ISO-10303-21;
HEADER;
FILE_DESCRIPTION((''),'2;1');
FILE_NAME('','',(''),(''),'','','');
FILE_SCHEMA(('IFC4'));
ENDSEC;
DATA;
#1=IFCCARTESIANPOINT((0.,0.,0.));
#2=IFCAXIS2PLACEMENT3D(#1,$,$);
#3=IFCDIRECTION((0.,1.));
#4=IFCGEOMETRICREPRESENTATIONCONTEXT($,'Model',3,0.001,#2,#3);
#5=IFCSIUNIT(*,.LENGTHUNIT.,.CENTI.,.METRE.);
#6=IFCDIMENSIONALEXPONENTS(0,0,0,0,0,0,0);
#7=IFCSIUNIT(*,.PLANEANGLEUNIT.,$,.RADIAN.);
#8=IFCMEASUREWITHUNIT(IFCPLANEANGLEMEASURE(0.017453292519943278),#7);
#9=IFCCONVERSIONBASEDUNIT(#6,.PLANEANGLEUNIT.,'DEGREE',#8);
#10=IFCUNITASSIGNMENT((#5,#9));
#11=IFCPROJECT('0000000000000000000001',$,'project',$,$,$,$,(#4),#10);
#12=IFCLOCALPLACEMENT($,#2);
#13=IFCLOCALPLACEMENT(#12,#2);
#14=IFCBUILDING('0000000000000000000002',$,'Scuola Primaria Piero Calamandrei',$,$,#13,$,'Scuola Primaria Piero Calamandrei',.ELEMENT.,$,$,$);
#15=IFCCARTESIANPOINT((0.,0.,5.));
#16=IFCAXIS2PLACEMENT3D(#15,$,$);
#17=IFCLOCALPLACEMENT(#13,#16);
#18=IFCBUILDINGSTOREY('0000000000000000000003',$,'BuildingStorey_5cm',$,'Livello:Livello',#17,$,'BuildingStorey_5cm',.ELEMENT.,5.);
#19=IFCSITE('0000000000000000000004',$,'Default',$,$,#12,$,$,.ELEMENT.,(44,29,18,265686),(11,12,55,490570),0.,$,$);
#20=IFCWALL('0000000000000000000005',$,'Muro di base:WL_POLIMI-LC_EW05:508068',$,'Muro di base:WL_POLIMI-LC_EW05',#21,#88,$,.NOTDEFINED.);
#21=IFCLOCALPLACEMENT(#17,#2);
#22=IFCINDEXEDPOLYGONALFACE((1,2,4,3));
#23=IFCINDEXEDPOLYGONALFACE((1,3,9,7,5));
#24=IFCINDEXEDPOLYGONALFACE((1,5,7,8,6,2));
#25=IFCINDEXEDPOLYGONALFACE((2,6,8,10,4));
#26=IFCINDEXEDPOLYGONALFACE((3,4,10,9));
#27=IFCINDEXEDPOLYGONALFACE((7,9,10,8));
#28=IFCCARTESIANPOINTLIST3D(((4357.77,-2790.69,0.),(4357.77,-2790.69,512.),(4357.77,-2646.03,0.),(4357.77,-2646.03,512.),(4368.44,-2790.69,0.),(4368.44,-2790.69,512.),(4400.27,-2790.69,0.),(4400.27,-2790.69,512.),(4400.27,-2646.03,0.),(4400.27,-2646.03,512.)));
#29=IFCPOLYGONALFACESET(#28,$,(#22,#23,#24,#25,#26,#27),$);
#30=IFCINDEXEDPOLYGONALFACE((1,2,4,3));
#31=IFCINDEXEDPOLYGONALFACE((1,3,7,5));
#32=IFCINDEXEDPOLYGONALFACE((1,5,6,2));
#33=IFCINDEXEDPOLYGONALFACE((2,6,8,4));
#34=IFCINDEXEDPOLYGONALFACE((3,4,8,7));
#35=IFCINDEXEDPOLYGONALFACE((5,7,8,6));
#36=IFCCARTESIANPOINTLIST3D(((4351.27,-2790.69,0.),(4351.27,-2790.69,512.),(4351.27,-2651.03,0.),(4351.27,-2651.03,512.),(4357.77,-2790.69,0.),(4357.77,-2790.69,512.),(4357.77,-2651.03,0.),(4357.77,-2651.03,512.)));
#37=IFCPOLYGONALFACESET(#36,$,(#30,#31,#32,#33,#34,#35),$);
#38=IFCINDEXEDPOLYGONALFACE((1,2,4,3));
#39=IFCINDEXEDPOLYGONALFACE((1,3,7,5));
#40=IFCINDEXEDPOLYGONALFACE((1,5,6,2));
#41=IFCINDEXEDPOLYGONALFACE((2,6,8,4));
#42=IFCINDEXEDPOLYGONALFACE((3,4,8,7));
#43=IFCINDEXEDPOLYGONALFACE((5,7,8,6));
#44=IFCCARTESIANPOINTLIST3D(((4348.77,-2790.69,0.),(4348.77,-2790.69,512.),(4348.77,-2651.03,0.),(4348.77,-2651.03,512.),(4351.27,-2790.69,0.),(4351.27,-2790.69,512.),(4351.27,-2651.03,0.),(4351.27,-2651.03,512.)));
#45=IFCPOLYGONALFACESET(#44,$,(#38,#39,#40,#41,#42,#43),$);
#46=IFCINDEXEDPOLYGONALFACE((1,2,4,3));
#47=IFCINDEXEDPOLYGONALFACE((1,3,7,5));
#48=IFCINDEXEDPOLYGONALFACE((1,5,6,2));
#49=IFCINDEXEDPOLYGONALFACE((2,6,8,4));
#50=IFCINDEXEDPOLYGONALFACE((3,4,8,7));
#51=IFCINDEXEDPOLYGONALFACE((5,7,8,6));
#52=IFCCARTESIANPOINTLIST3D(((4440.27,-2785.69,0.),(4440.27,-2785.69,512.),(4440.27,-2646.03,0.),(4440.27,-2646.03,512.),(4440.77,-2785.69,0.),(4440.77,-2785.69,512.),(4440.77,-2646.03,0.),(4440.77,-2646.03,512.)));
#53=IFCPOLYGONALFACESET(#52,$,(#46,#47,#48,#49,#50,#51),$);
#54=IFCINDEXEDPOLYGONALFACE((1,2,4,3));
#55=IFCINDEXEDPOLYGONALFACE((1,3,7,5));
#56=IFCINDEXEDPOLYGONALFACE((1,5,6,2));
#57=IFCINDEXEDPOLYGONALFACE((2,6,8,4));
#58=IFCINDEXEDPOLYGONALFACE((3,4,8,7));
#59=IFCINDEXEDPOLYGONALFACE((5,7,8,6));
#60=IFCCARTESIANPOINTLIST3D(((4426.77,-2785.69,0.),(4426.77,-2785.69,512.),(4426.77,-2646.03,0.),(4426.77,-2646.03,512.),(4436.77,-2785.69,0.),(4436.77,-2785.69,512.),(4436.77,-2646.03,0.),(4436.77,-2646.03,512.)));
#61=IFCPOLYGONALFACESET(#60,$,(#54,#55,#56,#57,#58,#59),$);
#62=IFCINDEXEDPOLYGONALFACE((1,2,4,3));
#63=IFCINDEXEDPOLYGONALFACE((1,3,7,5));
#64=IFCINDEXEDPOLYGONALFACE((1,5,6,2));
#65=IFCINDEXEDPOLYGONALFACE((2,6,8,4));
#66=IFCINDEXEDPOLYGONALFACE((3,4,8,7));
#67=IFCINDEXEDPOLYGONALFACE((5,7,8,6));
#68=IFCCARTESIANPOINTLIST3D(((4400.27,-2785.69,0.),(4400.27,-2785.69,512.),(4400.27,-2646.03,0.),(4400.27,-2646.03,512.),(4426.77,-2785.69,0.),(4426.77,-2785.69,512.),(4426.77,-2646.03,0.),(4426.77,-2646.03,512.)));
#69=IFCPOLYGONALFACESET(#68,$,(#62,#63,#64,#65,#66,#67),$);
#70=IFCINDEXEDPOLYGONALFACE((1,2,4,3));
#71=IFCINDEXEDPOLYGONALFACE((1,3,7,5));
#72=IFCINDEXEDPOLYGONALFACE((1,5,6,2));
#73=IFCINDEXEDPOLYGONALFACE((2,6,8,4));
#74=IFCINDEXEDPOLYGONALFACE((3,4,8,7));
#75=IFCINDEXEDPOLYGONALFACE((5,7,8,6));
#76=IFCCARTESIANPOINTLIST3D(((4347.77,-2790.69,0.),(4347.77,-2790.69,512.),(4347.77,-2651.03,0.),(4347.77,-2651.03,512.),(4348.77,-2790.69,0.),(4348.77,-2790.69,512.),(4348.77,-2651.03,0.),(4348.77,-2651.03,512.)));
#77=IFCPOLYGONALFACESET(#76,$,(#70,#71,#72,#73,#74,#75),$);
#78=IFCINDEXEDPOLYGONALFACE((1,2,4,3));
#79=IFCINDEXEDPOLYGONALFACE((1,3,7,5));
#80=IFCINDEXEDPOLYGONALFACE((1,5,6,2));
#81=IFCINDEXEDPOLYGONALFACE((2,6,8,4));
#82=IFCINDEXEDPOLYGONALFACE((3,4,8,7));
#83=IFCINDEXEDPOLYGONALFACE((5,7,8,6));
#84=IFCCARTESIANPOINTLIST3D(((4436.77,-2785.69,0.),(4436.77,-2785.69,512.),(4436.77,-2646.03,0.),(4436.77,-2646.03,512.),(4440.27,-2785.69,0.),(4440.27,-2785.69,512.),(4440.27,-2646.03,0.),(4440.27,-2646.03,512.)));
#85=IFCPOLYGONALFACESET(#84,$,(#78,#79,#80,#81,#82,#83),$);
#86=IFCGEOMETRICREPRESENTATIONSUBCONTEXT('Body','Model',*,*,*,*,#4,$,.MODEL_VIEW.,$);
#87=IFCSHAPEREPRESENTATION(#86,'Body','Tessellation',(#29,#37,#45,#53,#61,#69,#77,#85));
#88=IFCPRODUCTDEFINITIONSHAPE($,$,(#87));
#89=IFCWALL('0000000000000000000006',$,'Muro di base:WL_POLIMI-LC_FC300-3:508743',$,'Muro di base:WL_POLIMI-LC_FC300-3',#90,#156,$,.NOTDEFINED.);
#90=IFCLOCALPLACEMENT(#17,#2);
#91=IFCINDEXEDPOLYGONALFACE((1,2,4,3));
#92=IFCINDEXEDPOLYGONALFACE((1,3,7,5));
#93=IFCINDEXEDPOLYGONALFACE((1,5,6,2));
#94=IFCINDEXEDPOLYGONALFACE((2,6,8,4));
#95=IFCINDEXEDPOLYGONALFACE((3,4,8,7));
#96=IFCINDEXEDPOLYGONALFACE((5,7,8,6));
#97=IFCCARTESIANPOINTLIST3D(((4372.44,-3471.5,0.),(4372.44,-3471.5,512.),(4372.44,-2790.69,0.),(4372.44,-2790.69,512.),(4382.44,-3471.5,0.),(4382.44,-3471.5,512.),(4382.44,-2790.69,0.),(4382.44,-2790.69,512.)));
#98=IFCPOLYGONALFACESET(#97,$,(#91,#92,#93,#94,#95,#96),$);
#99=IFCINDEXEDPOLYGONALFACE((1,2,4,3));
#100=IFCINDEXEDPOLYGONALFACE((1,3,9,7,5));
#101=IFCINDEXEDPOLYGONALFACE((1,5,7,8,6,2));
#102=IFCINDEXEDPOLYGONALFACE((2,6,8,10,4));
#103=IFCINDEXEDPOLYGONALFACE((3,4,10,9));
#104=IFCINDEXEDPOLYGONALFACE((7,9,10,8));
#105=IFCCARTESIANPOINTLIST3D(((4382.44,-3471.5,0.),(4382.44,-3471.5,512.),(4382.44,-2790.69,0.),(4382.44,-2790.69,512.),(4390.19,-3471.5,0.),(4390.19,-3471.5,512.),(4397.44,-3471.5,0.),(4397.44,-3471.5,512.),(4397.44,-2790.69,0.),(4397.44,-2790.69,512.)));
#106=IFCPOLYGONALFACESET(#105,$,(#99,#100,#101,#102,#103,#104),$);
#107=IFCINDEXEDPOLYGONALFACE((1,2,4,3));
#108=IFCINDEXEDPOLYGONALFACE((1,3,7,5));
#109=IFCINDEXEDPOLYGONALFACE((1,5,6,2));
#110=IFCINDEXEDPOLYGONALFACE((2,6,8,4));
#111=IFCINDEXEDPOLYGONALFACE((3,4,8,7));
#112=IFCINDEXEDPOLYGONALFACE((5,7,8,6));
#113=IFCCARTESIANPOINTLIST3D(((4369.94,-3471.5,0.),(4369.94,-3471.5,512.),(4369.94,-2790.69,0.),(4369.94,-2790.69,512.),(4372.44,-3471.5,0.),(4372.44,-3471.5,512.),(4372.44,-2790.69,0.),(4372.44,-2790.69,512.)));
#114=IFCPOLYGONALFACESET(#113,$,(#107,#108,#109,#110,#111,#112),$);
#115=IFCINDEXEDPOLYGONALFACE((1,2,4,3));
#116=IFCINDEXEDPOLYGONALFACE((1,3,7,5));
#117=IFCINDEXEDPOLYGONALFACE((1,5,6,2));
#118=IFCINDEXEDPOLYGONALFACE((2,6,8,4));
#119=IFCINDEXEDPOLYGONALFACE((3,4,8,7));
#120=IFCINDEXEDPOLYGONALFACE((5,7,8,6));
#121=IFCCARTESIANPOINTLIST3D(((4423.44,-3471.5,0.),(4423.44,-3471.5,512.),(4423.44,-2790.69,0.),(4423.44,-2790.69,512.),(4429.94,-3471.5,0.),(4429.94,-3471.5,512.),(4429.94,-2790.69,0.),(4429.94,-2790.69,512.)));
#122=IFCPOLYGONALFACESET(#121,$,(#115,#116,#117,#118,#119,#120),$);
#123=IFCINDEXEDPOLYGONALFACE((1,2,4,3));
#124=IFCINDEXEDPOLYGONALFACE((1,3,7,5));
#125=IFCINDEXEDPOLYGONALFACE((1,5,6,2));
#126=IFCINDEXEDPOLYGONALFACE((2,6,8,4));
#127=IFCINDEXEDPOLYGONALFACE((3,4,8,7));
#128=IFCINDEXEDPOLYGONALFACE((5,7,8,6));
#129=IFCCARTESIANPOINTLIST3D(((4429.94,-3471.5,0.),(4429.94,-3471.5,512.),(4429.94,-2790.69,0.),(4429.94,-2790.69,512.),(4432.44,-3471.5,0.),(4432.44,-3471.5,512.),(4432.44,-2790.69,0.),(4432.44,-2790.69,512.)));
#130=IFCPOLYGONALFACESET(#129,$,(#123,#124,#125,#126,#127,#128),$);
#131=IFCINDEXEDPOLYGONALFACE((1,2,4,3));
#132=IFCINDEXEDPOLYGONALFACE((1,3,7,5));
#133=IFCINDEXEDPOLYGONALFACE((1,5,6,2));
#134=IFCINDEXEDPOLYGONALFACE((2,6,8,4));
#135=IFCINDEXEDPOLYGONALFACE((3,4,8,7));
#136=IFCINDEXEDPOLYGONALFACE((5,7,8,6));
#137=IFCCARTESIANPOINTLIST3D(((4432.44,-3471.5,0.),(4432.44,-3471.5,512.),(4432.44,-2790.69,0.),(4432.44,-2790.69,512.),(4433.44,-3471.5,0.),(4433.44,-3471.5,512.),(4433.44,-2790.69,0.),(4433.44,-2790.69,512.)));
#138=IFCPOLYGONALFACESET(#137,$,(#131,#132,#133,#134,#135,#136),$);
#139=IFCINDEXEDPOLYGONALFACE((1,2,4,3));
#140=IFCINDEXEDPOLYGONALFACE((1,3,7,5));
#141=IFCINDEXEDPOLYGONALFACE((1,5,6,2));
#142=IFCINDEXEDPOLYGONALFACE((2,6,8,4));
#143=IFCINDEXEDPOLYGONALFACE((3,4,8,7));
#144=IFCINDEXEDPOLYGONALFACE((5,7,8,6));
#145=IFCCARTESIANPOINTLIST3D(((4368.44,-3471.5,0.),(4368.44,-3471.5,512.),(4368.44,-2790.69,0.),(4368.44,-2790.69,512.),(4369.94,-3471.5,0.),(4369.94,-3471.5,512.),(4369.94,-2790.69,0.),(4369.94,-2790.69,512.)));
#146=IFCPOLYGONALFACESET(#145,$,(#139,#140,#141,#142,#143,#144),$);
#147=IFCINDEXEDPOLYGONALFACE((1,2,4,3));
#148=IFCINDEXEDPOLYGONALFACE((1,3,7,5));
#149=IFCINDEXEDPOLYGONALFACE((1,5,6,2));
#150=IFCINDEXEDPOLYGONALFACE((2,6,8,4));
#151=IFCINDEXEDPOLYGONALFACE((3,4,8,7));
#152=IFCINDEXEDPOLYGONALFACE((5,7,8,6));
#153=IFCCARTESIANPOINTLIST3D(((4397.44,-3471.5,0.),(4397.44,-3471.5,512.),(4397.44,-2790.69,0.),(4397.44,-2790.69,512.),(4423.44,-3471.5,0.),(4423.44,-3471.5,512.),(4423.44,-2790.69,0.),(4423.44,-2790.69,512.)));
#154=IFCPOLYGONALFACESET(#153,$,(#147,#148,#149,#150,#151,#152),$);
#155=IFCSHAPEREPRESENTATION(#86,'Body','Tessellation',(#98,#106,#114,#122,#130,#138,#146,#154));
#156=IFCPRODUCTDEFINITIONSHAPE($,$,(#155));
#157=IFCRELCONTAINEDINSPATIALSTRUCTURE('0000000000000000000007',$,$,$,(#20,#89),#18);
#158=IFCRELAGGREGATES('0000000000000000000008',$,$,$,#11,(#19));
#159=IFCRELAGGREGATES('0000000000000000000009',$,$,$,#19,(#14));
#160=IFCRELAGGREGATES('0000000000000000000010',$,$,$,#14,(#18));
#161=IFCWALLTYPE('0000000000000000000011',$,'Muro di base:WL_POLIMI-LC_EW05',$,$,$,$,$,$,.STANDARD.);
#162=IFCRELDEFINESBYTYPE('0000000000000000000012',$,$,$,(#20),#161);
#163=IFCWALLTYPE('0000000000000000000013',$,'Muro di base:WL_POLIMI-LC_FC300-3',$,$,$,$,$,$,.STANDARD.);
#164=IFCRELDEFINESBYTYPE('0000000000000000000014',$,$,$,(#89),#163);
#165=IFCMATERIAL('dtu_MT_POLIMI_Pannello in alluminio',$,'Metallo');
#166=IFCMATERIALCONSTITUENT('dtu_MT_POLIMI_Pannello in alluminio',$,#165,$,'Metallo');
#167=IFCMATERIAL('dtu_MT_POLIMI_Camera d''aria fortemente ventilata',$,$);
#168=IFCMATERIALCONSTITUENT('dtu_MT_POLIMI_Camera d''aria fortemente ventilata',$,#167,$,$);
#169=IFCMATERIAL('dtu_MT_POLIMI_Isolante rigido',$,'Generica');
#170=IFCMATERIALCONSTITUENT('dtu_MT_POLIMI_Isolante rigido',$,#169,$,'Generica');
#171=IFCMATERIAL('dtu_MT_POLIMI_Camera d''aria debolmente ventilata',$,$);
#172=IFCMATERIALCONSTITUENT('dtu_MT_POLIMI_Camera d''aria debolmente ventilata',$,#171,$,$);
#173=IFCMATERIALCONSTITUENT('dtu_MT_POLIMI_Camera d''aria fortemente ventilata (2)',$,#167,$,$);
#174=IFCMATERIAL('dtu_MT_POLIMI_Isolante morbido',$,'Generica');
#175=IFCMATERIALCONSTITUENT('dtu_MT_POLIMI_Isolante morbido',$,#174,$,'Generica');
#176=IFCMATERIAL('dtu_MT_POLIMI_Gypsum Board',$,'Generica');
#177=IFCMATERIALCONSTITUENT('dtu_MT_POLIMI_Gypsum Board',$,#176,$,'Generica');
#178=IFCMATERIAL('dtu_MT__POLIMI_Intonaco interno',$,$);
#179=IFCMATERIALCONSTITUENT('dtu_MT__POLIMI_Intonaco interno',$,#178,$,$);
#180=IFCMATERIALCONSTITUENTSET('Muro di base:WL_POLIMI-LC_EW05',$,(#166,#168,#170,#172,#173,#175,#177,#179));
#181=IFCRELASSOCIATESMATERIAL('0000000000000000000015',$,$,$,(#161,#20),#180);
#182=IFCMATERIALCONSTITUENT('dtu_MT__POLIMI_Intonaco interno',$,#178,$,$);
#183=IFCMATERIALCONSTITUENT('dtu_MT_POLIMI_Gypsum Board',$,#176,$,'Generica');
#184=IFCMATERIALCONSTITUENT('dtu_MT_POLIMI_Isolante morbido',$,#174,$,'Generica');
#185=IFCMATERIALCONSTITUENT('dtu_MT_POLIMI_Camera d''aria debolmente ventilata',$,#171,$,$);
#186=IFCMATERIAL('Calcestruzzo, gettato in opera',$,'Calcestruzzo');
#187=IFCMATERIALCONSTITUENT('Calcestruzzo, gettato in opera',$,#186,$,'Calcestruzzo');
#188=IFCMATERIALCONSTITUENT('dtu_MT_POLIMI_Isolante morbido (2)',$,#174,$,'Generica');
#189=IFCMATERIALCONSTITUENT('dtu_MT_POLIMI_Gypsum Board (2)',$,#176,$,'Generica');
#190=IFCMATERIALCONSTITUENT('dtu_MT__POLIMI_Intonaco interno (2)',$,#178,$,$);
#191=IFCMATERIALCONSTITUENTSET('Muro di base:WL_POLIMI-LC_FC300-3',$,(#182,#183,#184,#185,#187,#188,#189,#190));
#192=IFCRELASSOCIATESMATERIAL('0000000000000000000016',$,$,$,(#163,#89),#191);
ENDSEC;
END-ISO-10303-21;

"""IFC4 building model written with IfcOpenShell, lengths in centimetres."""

from ifc_helpers import new_model, entity, si_unit, converted_unit, direction, frame, origin, place, context, subcontext, project, spatial, indexed_curve, outline, extrude, material, constituent, constituent_set, type_object, element, save


model = new_model("IFC4")

# Units and contexts
model_context = context("Model", 3, precision=0.001, world=origin(), true_north=direction((0.0, 1.0)))
body_context = subcontext(model_context, "Body", "Model", "MODEL_VIEW")
ifc_project = project(units=[si_unit("LENGTHUNIT", "METRE", prefix="CENTI"), converted_unit("PLANEANGLEUNIT", "DEGREE", entity("IfcPlaneAngleMeasure", 0.017453292519943278), si_unit("PLANEANGLEUNIT", "RADIAN"), dimensions=[0, 0, 0, 0, 0, 0, 0])], contexts=[model_context])

# Site, building, storey
site_placement = place(None, origin())
site = spatial("IfcSite", under=ifc_project, at=site_placement, Name="Default", CompositionType="ELEMENT", RefLatitude=(44, 29, 18, 265686), RefLongitude=(11, 12, 55, 490570), RefElevation=0.0)
building_placement = place(site_placement, origin())
building = spatial("IfcBuilding", under=site, at=building_placement, Name="Scuola Primaria Piero Calamandrei", LongName="Scuola Primaria Piero Calamandrei", CompositionType="ELEMENT")
storey_placement = place(building_placement, frame((0.0, 0.0, 5.0)))
storey = spatial("IfcBuildingStorey", under=building, at=storey_placement, Name="BuildingStorey_5cm", ObjectType="Livello:Livello", LongName="BuildingStorey_5cm", CompositionType="ELEMENT", Elevation=5.0)

# Shared definitions
ifc_material_1 = material(Name="dtu_MT_POLIMI_Isolante rigido", Category="Generica")

# Walls
ifc_material_2 = material(Name="dtu_MT_POLIMI_Pannello in alluminio", Category="Metallo")
ifc_constituent_1 = constituent(ifc_material_2, Name="dtu_MT_POLIMI_Pannello in alluminio", Category="Metallo")
ifc_material_3 = material(Name="dtu_MT_POLIMI_Camera d'aria fortemente ventilata")
ifc_constituent_2 = constituent(ifc_material_3, Name="dtu_MT_POLIMI_Camera d'aria fortemente ventilata")
ifc_constituent_3 = constituent(ifc_material_1, Name="dtu_MT_POLIMI_Isolante rigido", Category="Generica")
ifc_material_4 = material(Name="dtu_MT_POLIMI_Camera d'aria debolmente ventilata")
ifc_constituent_4 = constituent(ifc_material_4, Name="dtu_MT_POLIMI_Camera d'aria debolmente ventilata")
ifc_constituent_5 = constituent(ifc_material_3, Name="dtu_MT_POLIMI_Camera d'aria fortemente ventilata (2)")
ifc_material_5 = material(Name="dtu_MT_POLIMI_Isolante morbido", Category="Generica")
ifc_constituent_6 = constituent(ifc_material_5, Name="dtu_MT_POLIMI_Isolante morbido", Category="Generica")
ifc_material_6 = material(Name="dtu_MT_POLIMI_Gypsum Board", Category="Generica")
ifc_constituent_7 = constituent(ifc_material_6, Name="dtu_MT_POLIMI_Gypsum Board", Category="Generica")
ifc_material_7 = material(Name="dtu_MT__POLIMI_Intonaco interno")
ifc_constituent_8 = constituent(ifc_material_7, Name="dtu_MT__POLIMI_Intonaco interno")
ifc_constituent_set_1 = constituent_set(constituents=[ifc_constituent_1, ifc_constituent_2, ifc_constituent_3, ifc_constituent_4, ifc_constituent_5, ifc_constituent_6, ifc_constituent_7, ifc_constituent_8], Name="Muro di base:WL_POLIMI-LC_EW05")
wall_type_1 = type_object("IfcWallType", Name="Muro di base:WL_POLIMI-LC_EW05", PredefinedType="STANDARD", material=ifc_constituent_set_1)
wall_1_placement = place(storey_placement, frame((4394.27, -2646.03, 0.0), z_axis=(0.0, 0.0, 1.0), x_axis=(0.0, -1.0, 0.0)))
element("IfcWall", 1, at=wall_1_placement, inside=storey, type_object=wall_type_1, material=ifc_constituent_set_1, Name="Muro di base:WL_POLIMI-LC_EW05:508068", ObjectType="Muro di base:WL_POLIMI-LC_EW05", PredefinedType="NOTDEFINED", context=body_context, shape_type="SweptSolid", body=[
    extrude(outline(indexed_curve([(-86.79, -19.13), (57.86, -19.13), (57.86, -8.47), (57.86, 23.37), (-86.79, 23.37), (-86.79, -19.13)], self_intersect=False)), frame((86.79, -17.37, 0.0)), (0.0, 0.0, 1.0), 512.0),
    extrude(outline(indexed_curve([(-69.83, -3.25), (69.83, -3.25), (69.83, 3.25), (-69.83, 3.25), (-69.83, -3.25)], self_intersect=False)), frame((74.83, -39.75, 0.0)), (0.0, 0.0, 1.0), 512.0),
    extrude(outline(indexed_curve([(-69.83, -1.25), (69.83, -1.25), (69.83, 1.25), (-69.83, 1.25), (-69.83, -1.25)], self_intersect=False)), frame((74.83, -44.25, 0.0)), (0.0, 0.0, 1.0), 512.0),
    extrude(outline(indexed_curve([(-69.83, -0.25), (69.83, -0.25), (69.83, 0.25), (-69.83, 0.25), (-69.83, -0.25)], self_intersect=False)), frame((69.83, 46.25, 0.0), z_axis=(0.0, 0.0, 1.0), x_axis=(-1.0, 0.0, 0.0)), (0.0, 0.0, 1.0), 512.0),
    extrude(outline(indexed_curve([(-69.83, -5.0), (69.83, -5.0), (69.83, 5.0), (-69.83, 5.0), (-69.83, -5.0)], self_intersect=False)), frame((69.83, 37.5, 0.0)), (0.0, 0.0, 1.0), 512.0),
    extrude(outline(indexed_curve([(-69.83, -13.25), (69.83, -13.25), (69.83, 13.25), (-69.83, 13.25), (-69.83, -13.25)], self_intersect=False)), frame((69.83, 19.25, 0.0)), (0.0, 0.0, 1.0), 512.0),
    extrude(outline(indexed_curve([(-69.83, -0.5), (69.83, -0.5), (69.83, 0.5), (-69.83, 0.5), (-69.83, -0.5)], self_intersect=False)), frame((74.83, -46.0, 0.0)), (0.0, 0.0, 1.0), 512.0),
    extrude(outline(indexed_curve([(-69.83, -1.75), (69.83, -1.75), (69.83, 1.75), (-69.83, 1.75), (-69.83, -1.75)], self_intersect=False)), frame((69.83, 44.25, 0.0)), (0.0, 0.0, 1.0), 512.0),
])
ifc_constituent_9 = constituent(ifc_material_7, Name="dtu_MT__POLIMI_Intonaco interno")
ifc_constituent_10 = constituent(ifc_material_6, Name="dtu_MT_POLIMI_Gypsum Board", Category="Generica")
ifc_constituent_11 = constituent(ifc_material_5, Name="dtu_MT_POLIMI_Isolante morbido", Category="Generica")
ifc_constituent_12 = constituent(ifc_material_4, Name="dtu_MT_POLIMI_Camera d'aria debolmente ventilata")
ifc_material_8 = material(Name="Calcestruzzo, gettato in opera", Category="Calcestruzzo")
ifc_constituent_13 = constituent(ifc_material_8, Name="Calcestruzzo, gettato in opera", Category="Calcestruzzo")
ifc_constituent_14 = constituent(ifc_material_5, Name="dtu_MT_POLIMI_Isolante morbido (2)", Category="Generica")
ifc_constituent_15 = constituent(ifc_material_6, Name="dtu_MT_POLIMI_Gypsum Board (2)", Category="Generica")
ifc_constituent_16 = constituent(ifc_material_7, Name="dtu_MT__POLIMI_Intonaco interno (2)")
ifc_constituent_set_2 = constituent_set(constituents=[ifc_constituent_9, ifc_constituent_10, ifc_constituent_11, ifc_constituent_12, ifc_constituent_13, ifc_constituent_14, ifc_constituent_15, ifc_constituent_16], Name="Muro di base:WL_POLIMI-LC_FC300-3")
wall_type_2 = type_object("IfcWallType", Name="Muro di base:WL_POLIMI-LC_FC300-3", PredefinedType="STANDARD", material=ifc_constituent_set_2)
wall_2_placement = place(storey_placement, frame((4400.94, -3471.5, 0.0), z_axis=(0.0, 0.0, 1.0), x_axis=(0.0, 1.0, 0.0)))
element("IfcWall", 2, at=wall_2_placement, inside=storey, type_object=wall_type_2, material=ifc_constituent_set_2, Name="Muro di base:WL_POLIMI-LC_FC300-3:508743", ObjectType="Muro di base:WL_POLIMI-LC_FC300-3", PredefinedType="NOTDEFINED", context=body_context, shape_type="SweptSolid", body=[
    extrude(outline(indexed_curve([(-340.41, -5.0), (340.41, -5.0), (340.41, 5.0), (-340.41, 5.0), (-340.41, -5.0)], self_intersect=False)), frame((340.41, 23.5, 0.0)), (0.0, 0.0, 1.0), 512.0),
    extrude(outline(indexed_curve([(-272.33, -7.45), (408.49, -7.45), (408.49, 7.55), (-272.33, 7.55), (-272.33, -0.2), (-272.33, -7.45)], self_intersect=False)), frame((272.33, 10.95, 0.0)), (0.0, 0.0, 1.0), 512.0),
    extrude(outline(indexed_curve([(-340.41, -1.25), (340.41, -1.25), (340.41, 1.25), (-340.41, 1.25), (-340.41, -1.25)], self_intersect=False)), frame((340.41, 29.75, 0.0)), (0.0, 0.0, 1.0), 512.0),
    extrude(outline(indexed_curve([(-340.41, -3.25), (340.41, -3.25), (340.41, 3.25), (-340.41, 3.25), (-340.41, -3.25)], self_intersect=False)), frame((340.41, -25.75, 0.0)), (0.0, 0.0, 1.0), 512.0),
    extrude(outline(indexed_curve([(-340.41, -1.25), (340.41, -1.25), (340.41, 1.25), (-340.41, 1.25), (-340.41, -1.25)], self_intersect=False)), frame((340.41, -30.25, 0.0)), (0.0, 0.0, 1.0), 512.0),
    extrude(outline(indexed_curve([(-0.5, -340.41), (0.5, -340.41), (0.5, 340.41), (-0.5, 340.41), (-0.5, -340.41)], self_intersect=False)), frame((340.41, -32.0, 0.0), z_axis=(0.0, 0.0, 1.0), x_axis=(0.0, 1.0, 0.0)), (0.0, 0.0, 1.0), 512.0),
    extrude(outline(indexed_curve([(-0.75, -340.41), (0.75, -340.41), (0.75, 340.41), (-0.75, 340.41), (-0.75, -340.41)], self_intersect=False)), frame((340.41, 31.75, 0.0), z_axis=(0.0, 0.0, 1.0), x_axis=(0.0, -1.0, 0.0)), (0.0, 0.0, 1.0), 512.0),
    extrude(outline(indexed_curve([(-340.41, -13.0), (340.41, -13.0), (340.41, 13.0), (-340.41, 13.0), (-340.41, -13.0)], self_intersect=False)), frame((340.41, -9.5, 0.0)), (0.0, 0.0, 1.0), 512.0),
])

save(model, "model.ifc")
